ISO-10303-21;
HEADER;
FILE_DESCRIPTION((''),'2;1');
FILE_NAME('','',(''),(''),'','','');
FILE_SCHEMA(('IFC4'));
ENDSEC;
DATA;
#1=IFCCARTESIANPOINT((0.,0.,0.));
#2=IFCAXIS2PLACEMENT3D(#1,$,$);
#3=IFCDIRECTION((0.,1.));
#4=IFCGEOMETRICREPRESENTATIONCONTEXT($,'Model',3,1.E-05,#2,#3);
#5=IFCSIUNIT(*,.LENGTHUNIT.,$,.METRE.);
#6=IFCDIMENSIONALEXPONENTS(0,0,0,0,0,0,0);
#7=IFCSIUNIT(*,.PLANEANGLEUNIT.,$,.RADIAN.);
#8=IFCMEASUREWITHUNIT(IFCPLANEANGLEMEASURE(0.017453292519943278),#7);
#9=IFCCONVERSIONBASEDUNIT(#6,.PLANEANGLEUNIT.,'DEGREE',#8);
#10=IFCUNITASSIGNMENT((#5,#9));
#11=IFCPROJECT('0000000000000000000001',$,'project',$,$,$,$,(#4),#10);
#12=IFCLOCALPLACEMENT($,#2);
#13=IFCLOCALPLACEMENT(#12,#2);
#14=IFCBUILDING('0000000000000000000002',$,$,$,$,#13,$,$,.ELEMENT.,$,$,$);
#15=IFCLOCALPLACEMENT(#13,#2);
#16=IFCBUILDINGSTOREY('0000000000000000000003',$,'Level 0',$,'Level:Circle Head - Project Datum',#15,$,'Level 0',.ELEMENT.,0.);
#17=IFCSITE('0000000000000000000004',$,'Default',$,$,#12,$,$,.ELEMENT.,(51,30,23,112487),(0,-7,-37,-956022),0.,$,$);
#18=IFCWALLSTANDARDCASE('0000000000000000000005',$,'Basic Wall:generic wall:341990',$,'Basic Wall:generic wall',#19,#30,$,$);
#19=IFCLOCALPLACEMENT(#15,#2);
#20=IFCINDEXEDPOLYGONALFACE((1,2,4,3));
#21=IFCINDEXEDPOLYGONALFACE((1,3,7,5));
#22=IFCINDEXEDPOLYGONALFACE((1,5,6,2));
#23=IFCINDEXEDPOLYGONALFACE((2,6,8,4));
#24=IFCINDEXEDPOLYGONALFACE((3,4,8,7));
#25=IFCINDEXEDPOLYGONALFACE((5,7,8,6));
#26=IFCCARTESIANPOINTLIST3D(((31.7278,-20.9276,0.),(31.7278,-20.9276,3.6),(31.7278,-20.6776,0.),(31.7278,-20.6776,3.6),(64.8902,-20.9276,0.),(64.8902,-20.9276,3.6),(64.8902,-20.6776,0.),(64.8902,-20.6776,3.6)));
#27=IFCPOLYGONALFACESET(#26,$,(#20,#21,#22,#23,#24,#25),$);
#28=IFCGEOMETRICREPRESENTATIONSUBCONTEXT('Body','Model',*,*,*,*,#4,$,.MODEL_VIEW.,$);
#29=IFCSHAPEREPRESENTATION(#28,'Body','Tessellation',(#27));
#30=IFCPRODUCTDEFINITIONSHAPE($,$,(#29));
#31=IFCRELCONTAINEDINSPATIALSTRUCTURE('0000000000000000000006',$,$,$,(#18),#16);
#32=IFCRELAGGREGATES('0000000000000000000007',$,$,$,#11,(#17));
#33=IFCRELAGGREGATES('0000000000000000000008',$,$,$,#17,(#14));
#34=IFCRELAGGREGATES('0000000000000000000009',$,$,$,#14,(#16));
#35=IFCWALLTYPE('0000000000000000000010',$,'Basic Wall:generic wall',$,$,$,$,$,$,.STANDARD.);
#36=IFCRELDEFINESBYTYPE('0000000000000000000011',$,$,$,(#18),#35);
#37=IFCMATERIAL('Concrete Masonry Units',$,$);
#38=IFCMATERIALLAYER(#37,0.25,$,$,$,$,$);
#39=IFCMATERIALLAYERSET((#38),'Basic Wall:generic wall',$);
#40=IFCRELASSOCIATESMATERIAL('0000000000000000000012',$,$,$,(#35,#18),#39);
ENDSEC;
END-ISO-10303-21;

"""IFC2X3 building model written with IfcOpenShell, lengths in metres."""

from ifc_helpers import new_model, entity, si_unit, converted_unit, direction, frame, frame_2d, origin, place, context, subcontext, project, spatial, rectangle, extrude, material, layer, layer_set, layer_usage, type_object, element, save


model = new_model("IFC2X3")

# Units and contexts
model_context = context("Model", 3, precision=1e-05, world=origin(), true_north=direction((0.0, 1.0)))
body_context = subcontext(model_context, "Body", "Model", "MODEL_VIEW")
ifc_project = project(units=[si_unit("LENGTHUNIT", "METRE"), converted_unit("PLANEANGLEUNIT", "DEGREE", entity("IfcPlaneAngleMeasure", 0.017453292519943278), si_unit("PLANEANGLEUNIT", "RADIAN"), dimensions=[0, 0, 0, 0, 0, 0, 0])], contexts=[model_context])

# Site, building, storey
site_placement = place(None, origin())
site = spatial("IfcSite", under=ifc_project, at=site_placement, Name="Default", CompositionType="ELEMENT", RefLatitude=(51, 30, 23, 112487), RefLongitude=(0, -7, -37, -956022), RefElevation=0.0)
building_placement = place(site_placement, origin())
building = spatial("IfcBuilding", under=site, at=building_placement, CompositionType="ELEMENT")
storey_placement = place(building_placement, origin())
storey = spatial("IfcBuildingStorey", under=building, at=storey_placement, Name="Level 0", ObjectType="Level:Circle Head - Project Datum", LongName="Level 0", CompositionType="ELEMENT", Elevation=0.0)

# Shared definitions
ifc_material = material(Name="Concrete Masonry Units")
ifc_layer = layer(ifc_material, 0.25)
ifc_layer_set = layer_set([ifc_layer], Name="Basic Wall:generic wall")
wall_type = type_object("IfcWallType", Name="Basic Wall:generic wall", PredefinedType="STANDARD", material=ifc_layer_set)

# Wall
ifc_layer_usage_1 = layer_usage(ifc_layer_set, "AXIS2", "NEGATIVE", 0.125)
wall_1_placement = place(storey_placement, frame((64.8902, -20.8026, 0.0), z_axis=(0.0, 0.0, 1.0), x_axis=(-1.0, 0.0, 0.0)))
element("IfcWallStandardCase", 1, at=wall_1_placement, inside=storey, type_object=wall_type, material=ifc_layer_usage_1, Name="Basic Wall:generic wall:341990", ObjectType="Basic Wall:generic wall", context=body_context, shape_type="SweptSolid", body=[
    extrude(rectangle(XDim=33.1623, YDim=0.25, at=frame_2d((16.5812, 0.0), x_axis=(-1.0, 0.0))), origin(), (0.0, 0.0, 1.0), 3.6),
])

save(model, "model.ifc")
